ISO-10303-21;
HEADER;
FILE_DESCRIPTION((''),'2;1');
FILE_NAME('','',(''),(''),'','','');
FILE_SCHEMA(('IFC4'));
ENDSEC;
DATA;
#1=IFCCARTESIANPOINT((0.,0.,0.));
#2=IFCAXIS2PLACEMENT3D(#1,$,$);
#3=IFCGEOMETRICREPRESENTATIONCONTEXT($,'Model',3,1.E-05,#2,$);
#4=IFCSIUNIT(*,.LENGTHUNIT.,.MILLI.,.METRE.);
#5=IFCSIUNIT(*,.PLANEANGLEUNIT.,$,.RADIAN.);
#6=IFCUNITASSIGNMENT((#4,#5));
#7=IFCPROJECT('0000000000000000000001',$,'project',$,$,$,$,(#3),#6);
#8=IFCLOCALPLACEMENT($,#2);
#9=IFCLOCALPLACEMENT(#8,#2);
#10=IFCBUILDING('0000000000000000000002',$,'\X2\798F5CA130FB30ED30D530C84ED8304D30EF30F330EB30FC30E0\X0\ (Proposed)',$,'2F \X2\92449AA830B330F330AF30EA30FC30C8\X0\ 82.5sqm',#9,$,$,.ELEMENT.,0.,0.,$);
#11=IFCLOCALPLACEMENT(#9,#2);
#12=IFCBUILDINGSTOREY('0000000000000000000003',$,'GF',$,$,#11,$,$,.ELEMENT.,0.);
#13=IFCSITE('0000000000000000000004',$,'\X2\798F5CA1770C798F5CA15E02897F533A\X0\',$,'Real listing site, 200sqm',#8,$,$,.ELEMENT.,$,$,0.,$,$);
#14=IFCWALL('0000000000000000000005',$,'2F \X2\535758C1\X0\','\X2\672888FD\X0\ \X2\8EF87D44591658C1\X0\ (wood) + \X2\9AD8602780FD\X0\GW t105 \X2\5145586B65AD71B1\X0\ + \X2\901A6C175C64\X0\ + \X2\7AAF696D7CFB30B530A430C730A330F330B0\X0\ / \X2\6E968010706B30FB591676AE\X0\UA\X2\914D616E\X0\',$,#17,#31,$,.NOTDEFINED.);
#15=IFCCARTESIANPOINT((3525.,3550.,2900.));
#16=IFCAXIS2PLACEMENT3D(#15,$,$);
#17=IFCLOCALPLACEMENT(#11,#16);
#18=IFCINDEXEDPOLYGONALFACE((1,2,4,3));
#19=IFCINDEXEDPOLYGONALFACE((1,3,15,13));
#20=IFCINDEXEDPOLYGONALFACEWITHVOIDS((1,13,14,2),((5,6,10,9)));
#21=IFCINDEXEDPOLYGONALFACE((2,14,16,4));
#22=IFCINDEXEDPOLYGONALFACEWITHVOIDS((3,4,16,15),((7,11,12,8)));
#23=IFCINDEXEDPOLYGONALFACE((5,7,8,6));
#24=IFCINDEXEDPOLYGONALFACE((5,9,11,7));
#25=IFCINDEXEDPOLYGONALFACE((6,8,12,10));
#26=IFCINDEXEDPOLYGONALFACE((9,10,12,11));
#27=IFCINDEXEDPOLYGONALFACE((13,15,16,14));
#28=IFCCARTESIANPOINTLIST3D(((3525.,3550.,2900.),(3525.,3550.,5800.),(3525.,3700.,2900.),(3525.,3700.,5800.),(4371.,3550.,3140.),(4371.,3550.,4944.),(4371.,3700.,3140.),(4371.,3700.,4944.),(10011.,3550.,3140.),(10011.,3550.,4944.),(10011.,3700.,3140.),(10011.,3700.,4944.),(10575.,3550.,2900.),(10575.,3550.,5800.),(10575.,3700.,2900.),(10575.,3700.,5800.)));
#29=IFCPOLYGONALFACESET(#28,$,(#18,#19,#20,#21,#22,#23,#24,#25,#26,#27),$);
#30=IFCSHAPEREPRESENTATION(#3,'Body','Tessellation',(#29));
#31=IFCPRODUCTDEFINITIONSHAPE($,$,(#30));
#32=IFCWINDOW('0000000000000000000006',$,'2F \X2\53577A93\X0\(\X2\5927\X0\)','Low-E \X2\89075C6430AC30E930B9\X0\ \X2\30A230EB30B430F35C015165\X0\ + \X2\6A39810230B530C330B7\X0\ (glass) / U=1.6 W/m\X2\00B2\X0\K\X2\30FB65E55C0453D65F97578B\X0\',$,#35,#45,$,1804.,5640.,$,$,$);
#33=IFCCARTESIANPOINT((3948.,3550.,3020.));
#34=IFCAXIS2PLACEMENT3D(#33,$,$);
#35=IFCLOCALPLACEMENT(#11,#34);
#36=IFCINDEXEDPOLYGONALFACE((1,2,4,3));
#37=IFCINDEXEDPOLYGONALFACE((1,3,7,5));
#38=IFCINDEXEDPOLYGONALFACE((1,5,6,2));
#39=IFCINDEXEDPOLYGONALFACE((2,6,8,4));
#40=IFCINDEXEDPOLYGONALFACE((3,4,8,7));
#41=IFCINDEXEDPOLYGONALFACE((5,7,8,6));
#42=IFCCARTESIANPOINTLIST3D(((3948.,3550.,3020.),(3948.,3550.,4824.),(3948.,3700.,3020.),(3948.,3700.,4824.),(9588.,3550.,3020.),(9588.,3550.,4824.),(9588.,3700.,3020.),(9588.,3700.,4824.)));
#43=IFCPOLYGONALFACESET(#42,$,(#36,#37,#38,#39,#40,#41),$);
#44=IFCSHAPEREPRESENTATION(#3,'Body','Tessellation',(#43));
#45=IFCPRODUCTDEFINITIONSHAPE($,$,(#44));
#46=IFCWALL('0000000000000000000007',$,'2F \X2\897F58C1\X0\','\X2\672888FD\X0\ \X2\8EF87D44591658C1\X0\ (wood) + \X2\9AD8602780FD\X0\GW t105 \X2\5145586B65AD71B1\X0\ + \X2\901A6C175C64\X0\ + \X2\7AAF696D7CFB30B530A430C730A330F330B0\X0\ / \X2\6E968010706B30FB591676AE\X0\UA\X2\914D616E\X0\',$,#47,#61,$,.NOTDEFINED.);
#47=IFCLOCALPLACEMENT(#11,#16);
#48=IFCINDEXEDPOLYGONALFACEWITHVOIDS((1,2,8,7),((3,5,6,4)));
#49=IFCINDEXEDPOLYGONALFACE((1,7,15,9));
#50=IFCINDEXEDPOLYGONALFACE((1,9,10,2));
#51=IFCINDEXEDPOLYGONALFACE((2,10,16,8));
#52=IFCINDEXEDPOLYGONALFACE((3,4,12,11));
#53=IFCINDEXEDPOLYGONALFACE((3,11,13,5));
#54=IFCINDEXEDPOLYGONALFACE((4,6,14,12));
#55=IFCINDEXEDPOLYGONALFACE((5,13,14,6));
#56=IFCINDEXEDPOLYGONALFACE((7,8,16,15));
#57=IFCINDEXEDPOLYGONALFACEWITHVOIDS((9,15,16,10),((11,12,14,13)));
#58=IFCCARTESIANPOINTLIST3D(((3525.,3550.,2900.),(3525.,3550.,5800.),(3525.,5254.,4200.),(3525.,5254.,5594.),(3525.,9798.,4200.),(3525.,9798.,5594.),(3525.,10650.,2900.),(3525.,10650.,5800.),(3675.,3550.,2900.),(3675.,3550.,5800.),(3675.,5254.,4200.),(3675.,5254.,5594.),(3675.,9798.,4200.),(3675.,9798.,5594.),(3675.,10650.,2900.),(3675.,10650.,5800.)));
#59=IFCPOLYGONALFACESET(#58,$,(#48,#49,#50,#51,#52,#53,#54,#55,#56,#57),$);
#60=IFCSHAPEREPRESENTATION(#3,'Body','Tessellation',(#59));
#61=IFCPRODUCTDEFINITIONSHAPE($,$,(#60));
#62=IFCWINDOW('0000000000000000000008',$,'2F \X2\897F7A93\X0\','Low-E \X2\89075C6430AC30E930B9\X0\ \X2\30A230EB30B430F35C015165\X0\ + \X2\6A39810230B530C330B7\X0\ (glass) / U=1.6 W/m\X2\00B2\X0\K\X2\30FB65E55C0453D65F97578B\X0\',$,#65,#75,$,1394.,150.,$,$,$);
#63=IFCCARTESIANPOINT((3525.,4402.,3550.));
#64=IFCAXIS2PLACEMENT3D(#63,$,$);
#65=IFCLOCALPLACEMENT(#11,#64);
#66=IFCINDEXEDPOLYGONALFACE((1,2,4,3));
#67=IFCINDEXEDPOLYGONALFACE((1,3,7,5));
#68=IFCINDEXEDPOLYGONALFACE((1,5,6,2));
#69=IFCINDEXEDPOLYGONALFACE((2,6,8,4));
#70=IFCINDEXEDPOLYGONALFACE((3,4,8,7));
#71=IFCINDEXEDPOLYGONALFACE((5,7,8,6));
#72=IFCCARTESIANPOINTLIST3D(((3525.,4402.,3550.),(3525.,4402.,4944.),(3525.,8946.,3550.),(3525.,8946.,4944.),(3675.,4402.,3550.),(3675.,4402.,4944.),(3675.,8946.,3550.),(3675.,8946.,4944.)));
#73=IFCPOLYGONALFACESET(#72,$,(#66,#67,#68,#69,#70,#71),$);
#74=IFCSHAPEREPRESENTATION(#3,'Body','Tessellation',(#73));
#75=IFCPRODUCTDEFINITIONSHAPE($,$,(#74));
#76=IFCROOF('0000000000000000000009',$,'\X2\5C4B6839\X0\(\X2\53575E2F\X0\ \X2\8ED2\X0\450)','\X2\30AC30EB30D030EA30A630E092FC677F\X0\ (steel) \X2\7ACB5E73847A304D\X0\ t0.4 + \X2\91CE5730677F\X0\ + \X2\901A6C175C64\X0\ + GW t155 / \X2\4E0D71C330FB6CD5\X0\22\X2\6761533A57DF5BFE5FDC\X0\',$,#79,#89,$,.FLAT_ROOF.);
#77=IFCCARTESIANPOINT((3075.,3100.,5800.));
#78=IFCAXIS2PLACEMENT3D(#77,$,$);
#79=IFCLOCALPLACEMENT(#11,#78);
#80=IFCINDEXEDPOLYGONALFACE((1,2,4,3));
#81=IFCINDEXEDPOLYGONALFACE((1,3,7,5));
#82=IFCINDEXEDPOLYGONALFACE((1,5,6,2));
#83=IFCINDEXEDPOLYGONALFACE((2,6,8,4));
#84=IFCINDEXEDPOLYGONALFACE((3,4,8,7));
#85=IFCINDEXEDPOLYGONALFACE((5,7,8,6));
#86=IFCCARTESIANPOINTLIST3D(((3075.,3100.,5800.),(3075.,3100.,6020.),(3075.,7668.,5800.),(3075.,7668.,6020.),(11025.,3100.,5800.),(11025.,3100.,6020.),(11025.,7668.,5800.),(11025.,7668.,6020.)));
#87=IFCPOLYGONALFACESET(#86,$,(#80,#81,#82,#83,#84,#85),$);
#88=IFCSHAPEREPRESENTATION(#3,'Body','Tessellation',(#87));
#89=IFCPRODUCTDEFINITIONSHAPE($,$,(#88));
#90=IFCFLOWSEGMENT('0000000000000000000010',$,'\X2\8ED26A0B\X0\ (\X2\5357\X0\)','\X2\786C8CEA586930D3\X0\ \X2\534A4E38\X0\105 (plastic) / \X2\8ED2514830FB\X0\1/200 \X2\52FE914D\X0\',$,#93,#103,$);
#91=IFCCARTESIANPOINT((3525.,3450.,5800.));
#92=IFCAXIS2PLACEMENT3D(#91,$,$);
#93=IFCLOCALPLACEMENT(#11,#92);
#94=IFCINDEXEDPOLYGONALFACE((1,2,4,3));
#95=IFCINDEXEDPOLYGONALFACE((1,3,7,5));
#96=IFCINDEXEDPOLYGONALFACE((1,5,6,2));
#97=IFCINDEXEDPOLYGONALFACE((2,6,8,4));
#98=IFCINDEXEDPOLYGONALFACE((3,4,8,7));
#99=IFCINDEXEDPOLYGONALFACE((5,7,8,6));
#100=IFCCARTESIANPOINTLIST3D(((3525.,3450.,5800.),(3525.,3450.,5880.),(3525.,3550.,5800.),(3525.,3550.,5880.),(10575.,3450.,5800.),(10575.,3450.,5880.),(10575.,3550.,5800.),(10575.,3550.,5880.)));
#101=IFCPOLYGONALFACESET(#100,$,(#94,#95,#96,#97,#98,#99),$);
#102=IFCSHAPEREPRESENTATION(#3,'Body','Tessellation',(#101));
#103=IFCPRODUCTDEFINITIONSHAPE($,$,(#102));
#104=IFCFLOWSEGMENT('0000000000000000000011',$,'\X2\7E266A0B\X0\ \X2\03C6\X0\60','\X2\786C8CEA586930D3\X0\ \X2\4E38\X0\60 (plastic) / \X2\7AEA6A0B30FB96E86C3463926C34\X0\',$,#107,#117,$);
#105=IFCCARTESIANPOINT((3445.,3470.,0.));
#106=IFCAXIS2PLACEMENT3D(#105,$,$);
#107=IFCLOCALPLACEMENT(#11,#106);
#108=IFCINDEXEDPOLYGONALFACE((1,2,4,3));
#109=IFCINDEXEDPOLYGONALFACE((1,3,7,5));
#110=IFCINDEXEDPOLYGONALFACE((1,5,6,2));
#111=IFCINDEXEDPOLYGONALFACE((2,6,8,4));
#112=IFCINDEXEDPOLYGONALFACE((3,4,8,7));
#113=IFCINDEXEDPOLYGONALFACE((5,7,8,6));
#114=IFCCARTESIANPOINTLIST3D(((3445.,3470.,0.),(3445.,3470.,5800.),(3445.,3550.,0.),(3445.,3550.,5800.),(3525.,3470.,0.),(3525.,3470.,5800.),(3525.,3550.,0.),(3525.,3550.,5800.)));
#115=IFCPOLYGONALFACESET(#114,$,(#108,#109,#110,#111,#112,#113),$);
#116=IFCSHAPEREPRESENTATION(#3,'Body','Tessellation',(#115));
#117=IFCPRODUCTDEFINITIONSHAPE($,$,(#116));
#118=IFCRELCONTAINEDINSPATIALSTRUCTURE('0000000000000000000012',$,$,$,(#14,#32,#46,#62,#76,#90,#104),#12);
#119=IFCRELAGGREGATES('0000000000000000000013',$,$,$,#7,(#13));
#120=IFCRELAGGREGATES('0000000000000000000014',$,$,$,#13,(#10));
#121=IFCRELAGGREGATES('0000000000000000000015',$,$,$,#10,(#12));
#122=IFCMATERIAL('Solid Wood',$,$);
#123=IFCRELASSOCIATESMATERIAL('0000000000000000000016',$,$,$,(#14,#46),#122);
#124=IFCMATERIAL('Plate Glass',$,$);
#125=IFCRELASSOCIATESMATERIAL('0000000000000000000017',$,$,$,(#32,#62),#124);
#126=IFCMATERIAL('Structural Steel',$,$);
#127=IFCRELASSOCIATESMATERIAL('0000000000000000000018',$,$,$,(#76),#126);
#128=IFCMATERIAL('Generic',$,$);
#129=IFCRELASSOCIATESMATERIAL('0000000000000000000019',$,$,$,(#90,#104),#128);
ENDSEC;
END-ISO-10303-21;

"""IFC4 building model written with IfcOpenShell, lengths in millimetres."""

from ifc_helpers import new_model, si_unit, frame, frame_2d, origin, place, context, project, spatial, rectangle, extrude, material, element, fill, save


model = new_model("IFC4")

# Units and contexts
model_context = context("Model", 3, precision=1e-05, world=origin())
ifc_project = project(units=[si_unit("LENGTHUNIT", "METRE", prefix="MILLI"), si_unit("PLANEANGLEUNIT", "RADIAN")], contexts=[model_context])

# Site, building, storey
site_placement = place(None, origin())
site = spatial("IfcSite", under=ifc_project, at=site_placement, Name="福岡県福岡市西区", ObjectType="Real listing site, 200sqm", CompositionType="ELEMENT", RefElevation=0.0)
building_placement = place(site_placement, origin())
building = spatial("IfcBuilding", under=site, at=building_placement, Name="福岡・ロフト付きワンルーム (Proposed)", ObjectType="2F 鉄骨コンクリート 82.5sqm", CompositionType="ELEMENT", ElevationOfRefHeight=0.0, ElevationOfTerrain=0.0)
storey_placement = place(building_placement, origin())
storey = spatial("IfcBuildingStorey", under=building, at=storey_placement, Name="GF", CompositionType="ELEMENT", Elevation=0.0)

# Shared definitions
ifc_material_1 = material(Name="Solid Wood")

# Shared definitions
ifc_material_2 = material(Name="Plate Glass")

# Walls, openings, windows
wall_1_placement = place(storey_placement, frame((3525.0, 3550.0, 2900.0)))
wall_1 = element("IfcWall", 1, at=wall_1_placement, inside=storey, material=ifc_material_1, Name="2F 南壁", Description="木製 軸組外壁 (wood) + 高性能GW t105 充填断熱 + 通気層 + 窯業系サイディング / 準耐火・外皮UA配慮", PredefinedType="NOTDEFINED", context=model_context, shape_type="SweptSolid", body=[
    extrude(rectangle(XDim=7050.0, YDim=150.0, at=frame_2d((3525.0, 75.0))), frame((3525.0, 3550.0, 2900.0)), (0.0, 0.0, 1.0), 2900.0),
])
opening_1_placement = place(storey_placement, frame((3948.0, 3550.0, 3020.0)))
opening_1 = element("IfcOpeningElement", 2, at=opening_1_placement, cuts=wall_1, PredefinedType="NOTDEFINED", context=model_context, shape_type="SweptSolid", body=[
    extrude(rectangle(XDim=5640.0, YDim=150.0, at=frame_2d((2820.0, 75.0))), frame((3948.0, 3550.0, 3020.0)), (0.0, 0.0, 1.0), 1804.0),
])
window_1_placement = place(storey_placement, frame((3948.0, 3550.0, 3020.0)))
window_1 = element("IfcWindow", 3, at=window_1_placement, inside=storey, material=ifc_material_2, Name="2F 南窓(大)", Description="Low-E 複層ガラス アルゴン封入 + 樹脂サッシ (glass) / U=1.6 W/m²K・日射取得型", OverallHeight=1804.0, OverallWidth=5640.0, context=model_context, shape_type="SweptSolid", body=[
    extrude(rectangle(XDim=5640.0, YDim=150.0, at=frame_2d((2820.0, 75.0))), frame((3948.0, 3550.0, 3020.0)), (0.0, 0.0, 1.0), 1804.0),
])
fill(opening_1, window_1)
wall_2_placement = place(storey_placement, frame((3525.0, 3550.0, 2900.0)))
wall_2 = element("IfcWall", 4, at=wall_2_placement, inside=storey, material=ifc_material_1, Name="2F 西壁", Description="木製 軸組外壁 (wood) + 高性能GW t105 充填断熱 + 通気層 + 窯業系サイディング / 準耐火・外皮UA配慮", PredefinedType="NOTDEFINED", context=model_context, shape_type="SweptSolid", body=[
    extrude(rectangle(XDim=150.0, YDim=7100.0, at=frame_2d((75.0, 3550.0))), frame((3525.0, 3550.0, 2900.0)), (0.0, 0.0, 1.0), 2900.0),
])
opening_2_placement = place(storey_placement, frame((3525.0, 4402.0, 3550.0)))
opening_2 = element("IfcOpeningElement", 5, at=opening_2_placement, cuts=wall_2, PredefinedType="NOTDEFINED", context=model_context, shape_type="SweptSolid", body=[
    extrude(rectangle(XDim=150.0, YDim=4544.0, at=frame_2d((75.0, 2272.0))), frame((3525.0, 4402.0, 3550.0)), (0.0, 0.0, 1.0), 1394.0),
])
window_2_placement = place(storey_placement, frame((3525.0, 4402.0, 3550.0)))
window_2 = element("IfcWindow", 6, at=window_2_placement, inside=storey, material=ifc_material_2, Name="2F 西窓", Description="Low-E 複層ガラス アルゴン封入 + 樹脂サッシ (glass) / U=1.6 W/m²K・日射取得型", OverallHeight=1394.0, OverallWidth=150.0, context=model_context, shape_type="SweptSolid", body=[
    extrude(rectangle(XDim=150.0, YDim=4544.0, at=frame_2d((75.0, 2272.0))), frame((3525.0, 4402.0, 3550.0)), (0.0, 0.0, 1.0), 1394.0),
])
fill(opening_2, window_2)

# Roof
ifc_material_3 = material(Name="Structural Steel")
for number, where, name in (
    (7, (3075.0, 3100.0, 5800.0), "屋根(南帯 軒450)"),
):
    element("IfcRoof", number, at=place(storey_placement, frame(where)), inside=storey, material=ifc_material_3, Name=name, Description="ガルバリウム鋼板 (steel) 立平葺き t0.4 + 野地板 + 通気層 + GW t155 / 不燃・法22条区域対応", PredefinedType="FLAT_ROOF", context=model_context, shape_type="SweptSolid", body=[
        extrude(rectangle(XDim=7950.0, YDim=4568.0, at=frame_2d((3975.0, 2284.0))), frame((3075.0, 3100.0, 5800.0)), (0.0, 0.0, 1.0), 220.0),
    ])

# Flow segments
ifc_material_4 = material(Name="Generic")
flow_segment_1_placement = place(storey_placement, frame((3525.0, 3450.0, 5800.0)))
element("IfcFlowSegment", 8, at=flow_segment_1_placement, inside=storey, material=ifc_material_4, Name="軒樋 (南)", Description="硬質塩ビ 半丸105 (plastic) / 軒先・1/200 勾配", context=model_context, shape_type="SweptSolid", body=[
    extrude(rectangle(XDim=7050.0, YDim=100.0, at=frame_2d((3525.0, 50.0))), frame((3525.0, 3450.0, 5800.0)), (0.0, 0.0, 1.0), 80.0),
])
flow_segment_2_placement = place(storey_placement, frame((3445.0, 3470.0, 0.0)))
element("IfcFlowSegment", 9, at=flow_segment_2_placement, inside=storey, material=ifc_material_4, Name="縦樋 φ60", Description="硬質塩ビ 丸60 (plastic) / 竪樋・雨水排水", context=model_context, shape_type="SweptSolid", body=[
    extrude(rectangle(XDim=80.0, YDim=80.0, at=frame_2d((40.0, 40.0))), frame((3445.0, 3470.0, 0.0)), (0.0, 0.0, 1.0), 5800.0),
])

save(model, "model.ifc")
